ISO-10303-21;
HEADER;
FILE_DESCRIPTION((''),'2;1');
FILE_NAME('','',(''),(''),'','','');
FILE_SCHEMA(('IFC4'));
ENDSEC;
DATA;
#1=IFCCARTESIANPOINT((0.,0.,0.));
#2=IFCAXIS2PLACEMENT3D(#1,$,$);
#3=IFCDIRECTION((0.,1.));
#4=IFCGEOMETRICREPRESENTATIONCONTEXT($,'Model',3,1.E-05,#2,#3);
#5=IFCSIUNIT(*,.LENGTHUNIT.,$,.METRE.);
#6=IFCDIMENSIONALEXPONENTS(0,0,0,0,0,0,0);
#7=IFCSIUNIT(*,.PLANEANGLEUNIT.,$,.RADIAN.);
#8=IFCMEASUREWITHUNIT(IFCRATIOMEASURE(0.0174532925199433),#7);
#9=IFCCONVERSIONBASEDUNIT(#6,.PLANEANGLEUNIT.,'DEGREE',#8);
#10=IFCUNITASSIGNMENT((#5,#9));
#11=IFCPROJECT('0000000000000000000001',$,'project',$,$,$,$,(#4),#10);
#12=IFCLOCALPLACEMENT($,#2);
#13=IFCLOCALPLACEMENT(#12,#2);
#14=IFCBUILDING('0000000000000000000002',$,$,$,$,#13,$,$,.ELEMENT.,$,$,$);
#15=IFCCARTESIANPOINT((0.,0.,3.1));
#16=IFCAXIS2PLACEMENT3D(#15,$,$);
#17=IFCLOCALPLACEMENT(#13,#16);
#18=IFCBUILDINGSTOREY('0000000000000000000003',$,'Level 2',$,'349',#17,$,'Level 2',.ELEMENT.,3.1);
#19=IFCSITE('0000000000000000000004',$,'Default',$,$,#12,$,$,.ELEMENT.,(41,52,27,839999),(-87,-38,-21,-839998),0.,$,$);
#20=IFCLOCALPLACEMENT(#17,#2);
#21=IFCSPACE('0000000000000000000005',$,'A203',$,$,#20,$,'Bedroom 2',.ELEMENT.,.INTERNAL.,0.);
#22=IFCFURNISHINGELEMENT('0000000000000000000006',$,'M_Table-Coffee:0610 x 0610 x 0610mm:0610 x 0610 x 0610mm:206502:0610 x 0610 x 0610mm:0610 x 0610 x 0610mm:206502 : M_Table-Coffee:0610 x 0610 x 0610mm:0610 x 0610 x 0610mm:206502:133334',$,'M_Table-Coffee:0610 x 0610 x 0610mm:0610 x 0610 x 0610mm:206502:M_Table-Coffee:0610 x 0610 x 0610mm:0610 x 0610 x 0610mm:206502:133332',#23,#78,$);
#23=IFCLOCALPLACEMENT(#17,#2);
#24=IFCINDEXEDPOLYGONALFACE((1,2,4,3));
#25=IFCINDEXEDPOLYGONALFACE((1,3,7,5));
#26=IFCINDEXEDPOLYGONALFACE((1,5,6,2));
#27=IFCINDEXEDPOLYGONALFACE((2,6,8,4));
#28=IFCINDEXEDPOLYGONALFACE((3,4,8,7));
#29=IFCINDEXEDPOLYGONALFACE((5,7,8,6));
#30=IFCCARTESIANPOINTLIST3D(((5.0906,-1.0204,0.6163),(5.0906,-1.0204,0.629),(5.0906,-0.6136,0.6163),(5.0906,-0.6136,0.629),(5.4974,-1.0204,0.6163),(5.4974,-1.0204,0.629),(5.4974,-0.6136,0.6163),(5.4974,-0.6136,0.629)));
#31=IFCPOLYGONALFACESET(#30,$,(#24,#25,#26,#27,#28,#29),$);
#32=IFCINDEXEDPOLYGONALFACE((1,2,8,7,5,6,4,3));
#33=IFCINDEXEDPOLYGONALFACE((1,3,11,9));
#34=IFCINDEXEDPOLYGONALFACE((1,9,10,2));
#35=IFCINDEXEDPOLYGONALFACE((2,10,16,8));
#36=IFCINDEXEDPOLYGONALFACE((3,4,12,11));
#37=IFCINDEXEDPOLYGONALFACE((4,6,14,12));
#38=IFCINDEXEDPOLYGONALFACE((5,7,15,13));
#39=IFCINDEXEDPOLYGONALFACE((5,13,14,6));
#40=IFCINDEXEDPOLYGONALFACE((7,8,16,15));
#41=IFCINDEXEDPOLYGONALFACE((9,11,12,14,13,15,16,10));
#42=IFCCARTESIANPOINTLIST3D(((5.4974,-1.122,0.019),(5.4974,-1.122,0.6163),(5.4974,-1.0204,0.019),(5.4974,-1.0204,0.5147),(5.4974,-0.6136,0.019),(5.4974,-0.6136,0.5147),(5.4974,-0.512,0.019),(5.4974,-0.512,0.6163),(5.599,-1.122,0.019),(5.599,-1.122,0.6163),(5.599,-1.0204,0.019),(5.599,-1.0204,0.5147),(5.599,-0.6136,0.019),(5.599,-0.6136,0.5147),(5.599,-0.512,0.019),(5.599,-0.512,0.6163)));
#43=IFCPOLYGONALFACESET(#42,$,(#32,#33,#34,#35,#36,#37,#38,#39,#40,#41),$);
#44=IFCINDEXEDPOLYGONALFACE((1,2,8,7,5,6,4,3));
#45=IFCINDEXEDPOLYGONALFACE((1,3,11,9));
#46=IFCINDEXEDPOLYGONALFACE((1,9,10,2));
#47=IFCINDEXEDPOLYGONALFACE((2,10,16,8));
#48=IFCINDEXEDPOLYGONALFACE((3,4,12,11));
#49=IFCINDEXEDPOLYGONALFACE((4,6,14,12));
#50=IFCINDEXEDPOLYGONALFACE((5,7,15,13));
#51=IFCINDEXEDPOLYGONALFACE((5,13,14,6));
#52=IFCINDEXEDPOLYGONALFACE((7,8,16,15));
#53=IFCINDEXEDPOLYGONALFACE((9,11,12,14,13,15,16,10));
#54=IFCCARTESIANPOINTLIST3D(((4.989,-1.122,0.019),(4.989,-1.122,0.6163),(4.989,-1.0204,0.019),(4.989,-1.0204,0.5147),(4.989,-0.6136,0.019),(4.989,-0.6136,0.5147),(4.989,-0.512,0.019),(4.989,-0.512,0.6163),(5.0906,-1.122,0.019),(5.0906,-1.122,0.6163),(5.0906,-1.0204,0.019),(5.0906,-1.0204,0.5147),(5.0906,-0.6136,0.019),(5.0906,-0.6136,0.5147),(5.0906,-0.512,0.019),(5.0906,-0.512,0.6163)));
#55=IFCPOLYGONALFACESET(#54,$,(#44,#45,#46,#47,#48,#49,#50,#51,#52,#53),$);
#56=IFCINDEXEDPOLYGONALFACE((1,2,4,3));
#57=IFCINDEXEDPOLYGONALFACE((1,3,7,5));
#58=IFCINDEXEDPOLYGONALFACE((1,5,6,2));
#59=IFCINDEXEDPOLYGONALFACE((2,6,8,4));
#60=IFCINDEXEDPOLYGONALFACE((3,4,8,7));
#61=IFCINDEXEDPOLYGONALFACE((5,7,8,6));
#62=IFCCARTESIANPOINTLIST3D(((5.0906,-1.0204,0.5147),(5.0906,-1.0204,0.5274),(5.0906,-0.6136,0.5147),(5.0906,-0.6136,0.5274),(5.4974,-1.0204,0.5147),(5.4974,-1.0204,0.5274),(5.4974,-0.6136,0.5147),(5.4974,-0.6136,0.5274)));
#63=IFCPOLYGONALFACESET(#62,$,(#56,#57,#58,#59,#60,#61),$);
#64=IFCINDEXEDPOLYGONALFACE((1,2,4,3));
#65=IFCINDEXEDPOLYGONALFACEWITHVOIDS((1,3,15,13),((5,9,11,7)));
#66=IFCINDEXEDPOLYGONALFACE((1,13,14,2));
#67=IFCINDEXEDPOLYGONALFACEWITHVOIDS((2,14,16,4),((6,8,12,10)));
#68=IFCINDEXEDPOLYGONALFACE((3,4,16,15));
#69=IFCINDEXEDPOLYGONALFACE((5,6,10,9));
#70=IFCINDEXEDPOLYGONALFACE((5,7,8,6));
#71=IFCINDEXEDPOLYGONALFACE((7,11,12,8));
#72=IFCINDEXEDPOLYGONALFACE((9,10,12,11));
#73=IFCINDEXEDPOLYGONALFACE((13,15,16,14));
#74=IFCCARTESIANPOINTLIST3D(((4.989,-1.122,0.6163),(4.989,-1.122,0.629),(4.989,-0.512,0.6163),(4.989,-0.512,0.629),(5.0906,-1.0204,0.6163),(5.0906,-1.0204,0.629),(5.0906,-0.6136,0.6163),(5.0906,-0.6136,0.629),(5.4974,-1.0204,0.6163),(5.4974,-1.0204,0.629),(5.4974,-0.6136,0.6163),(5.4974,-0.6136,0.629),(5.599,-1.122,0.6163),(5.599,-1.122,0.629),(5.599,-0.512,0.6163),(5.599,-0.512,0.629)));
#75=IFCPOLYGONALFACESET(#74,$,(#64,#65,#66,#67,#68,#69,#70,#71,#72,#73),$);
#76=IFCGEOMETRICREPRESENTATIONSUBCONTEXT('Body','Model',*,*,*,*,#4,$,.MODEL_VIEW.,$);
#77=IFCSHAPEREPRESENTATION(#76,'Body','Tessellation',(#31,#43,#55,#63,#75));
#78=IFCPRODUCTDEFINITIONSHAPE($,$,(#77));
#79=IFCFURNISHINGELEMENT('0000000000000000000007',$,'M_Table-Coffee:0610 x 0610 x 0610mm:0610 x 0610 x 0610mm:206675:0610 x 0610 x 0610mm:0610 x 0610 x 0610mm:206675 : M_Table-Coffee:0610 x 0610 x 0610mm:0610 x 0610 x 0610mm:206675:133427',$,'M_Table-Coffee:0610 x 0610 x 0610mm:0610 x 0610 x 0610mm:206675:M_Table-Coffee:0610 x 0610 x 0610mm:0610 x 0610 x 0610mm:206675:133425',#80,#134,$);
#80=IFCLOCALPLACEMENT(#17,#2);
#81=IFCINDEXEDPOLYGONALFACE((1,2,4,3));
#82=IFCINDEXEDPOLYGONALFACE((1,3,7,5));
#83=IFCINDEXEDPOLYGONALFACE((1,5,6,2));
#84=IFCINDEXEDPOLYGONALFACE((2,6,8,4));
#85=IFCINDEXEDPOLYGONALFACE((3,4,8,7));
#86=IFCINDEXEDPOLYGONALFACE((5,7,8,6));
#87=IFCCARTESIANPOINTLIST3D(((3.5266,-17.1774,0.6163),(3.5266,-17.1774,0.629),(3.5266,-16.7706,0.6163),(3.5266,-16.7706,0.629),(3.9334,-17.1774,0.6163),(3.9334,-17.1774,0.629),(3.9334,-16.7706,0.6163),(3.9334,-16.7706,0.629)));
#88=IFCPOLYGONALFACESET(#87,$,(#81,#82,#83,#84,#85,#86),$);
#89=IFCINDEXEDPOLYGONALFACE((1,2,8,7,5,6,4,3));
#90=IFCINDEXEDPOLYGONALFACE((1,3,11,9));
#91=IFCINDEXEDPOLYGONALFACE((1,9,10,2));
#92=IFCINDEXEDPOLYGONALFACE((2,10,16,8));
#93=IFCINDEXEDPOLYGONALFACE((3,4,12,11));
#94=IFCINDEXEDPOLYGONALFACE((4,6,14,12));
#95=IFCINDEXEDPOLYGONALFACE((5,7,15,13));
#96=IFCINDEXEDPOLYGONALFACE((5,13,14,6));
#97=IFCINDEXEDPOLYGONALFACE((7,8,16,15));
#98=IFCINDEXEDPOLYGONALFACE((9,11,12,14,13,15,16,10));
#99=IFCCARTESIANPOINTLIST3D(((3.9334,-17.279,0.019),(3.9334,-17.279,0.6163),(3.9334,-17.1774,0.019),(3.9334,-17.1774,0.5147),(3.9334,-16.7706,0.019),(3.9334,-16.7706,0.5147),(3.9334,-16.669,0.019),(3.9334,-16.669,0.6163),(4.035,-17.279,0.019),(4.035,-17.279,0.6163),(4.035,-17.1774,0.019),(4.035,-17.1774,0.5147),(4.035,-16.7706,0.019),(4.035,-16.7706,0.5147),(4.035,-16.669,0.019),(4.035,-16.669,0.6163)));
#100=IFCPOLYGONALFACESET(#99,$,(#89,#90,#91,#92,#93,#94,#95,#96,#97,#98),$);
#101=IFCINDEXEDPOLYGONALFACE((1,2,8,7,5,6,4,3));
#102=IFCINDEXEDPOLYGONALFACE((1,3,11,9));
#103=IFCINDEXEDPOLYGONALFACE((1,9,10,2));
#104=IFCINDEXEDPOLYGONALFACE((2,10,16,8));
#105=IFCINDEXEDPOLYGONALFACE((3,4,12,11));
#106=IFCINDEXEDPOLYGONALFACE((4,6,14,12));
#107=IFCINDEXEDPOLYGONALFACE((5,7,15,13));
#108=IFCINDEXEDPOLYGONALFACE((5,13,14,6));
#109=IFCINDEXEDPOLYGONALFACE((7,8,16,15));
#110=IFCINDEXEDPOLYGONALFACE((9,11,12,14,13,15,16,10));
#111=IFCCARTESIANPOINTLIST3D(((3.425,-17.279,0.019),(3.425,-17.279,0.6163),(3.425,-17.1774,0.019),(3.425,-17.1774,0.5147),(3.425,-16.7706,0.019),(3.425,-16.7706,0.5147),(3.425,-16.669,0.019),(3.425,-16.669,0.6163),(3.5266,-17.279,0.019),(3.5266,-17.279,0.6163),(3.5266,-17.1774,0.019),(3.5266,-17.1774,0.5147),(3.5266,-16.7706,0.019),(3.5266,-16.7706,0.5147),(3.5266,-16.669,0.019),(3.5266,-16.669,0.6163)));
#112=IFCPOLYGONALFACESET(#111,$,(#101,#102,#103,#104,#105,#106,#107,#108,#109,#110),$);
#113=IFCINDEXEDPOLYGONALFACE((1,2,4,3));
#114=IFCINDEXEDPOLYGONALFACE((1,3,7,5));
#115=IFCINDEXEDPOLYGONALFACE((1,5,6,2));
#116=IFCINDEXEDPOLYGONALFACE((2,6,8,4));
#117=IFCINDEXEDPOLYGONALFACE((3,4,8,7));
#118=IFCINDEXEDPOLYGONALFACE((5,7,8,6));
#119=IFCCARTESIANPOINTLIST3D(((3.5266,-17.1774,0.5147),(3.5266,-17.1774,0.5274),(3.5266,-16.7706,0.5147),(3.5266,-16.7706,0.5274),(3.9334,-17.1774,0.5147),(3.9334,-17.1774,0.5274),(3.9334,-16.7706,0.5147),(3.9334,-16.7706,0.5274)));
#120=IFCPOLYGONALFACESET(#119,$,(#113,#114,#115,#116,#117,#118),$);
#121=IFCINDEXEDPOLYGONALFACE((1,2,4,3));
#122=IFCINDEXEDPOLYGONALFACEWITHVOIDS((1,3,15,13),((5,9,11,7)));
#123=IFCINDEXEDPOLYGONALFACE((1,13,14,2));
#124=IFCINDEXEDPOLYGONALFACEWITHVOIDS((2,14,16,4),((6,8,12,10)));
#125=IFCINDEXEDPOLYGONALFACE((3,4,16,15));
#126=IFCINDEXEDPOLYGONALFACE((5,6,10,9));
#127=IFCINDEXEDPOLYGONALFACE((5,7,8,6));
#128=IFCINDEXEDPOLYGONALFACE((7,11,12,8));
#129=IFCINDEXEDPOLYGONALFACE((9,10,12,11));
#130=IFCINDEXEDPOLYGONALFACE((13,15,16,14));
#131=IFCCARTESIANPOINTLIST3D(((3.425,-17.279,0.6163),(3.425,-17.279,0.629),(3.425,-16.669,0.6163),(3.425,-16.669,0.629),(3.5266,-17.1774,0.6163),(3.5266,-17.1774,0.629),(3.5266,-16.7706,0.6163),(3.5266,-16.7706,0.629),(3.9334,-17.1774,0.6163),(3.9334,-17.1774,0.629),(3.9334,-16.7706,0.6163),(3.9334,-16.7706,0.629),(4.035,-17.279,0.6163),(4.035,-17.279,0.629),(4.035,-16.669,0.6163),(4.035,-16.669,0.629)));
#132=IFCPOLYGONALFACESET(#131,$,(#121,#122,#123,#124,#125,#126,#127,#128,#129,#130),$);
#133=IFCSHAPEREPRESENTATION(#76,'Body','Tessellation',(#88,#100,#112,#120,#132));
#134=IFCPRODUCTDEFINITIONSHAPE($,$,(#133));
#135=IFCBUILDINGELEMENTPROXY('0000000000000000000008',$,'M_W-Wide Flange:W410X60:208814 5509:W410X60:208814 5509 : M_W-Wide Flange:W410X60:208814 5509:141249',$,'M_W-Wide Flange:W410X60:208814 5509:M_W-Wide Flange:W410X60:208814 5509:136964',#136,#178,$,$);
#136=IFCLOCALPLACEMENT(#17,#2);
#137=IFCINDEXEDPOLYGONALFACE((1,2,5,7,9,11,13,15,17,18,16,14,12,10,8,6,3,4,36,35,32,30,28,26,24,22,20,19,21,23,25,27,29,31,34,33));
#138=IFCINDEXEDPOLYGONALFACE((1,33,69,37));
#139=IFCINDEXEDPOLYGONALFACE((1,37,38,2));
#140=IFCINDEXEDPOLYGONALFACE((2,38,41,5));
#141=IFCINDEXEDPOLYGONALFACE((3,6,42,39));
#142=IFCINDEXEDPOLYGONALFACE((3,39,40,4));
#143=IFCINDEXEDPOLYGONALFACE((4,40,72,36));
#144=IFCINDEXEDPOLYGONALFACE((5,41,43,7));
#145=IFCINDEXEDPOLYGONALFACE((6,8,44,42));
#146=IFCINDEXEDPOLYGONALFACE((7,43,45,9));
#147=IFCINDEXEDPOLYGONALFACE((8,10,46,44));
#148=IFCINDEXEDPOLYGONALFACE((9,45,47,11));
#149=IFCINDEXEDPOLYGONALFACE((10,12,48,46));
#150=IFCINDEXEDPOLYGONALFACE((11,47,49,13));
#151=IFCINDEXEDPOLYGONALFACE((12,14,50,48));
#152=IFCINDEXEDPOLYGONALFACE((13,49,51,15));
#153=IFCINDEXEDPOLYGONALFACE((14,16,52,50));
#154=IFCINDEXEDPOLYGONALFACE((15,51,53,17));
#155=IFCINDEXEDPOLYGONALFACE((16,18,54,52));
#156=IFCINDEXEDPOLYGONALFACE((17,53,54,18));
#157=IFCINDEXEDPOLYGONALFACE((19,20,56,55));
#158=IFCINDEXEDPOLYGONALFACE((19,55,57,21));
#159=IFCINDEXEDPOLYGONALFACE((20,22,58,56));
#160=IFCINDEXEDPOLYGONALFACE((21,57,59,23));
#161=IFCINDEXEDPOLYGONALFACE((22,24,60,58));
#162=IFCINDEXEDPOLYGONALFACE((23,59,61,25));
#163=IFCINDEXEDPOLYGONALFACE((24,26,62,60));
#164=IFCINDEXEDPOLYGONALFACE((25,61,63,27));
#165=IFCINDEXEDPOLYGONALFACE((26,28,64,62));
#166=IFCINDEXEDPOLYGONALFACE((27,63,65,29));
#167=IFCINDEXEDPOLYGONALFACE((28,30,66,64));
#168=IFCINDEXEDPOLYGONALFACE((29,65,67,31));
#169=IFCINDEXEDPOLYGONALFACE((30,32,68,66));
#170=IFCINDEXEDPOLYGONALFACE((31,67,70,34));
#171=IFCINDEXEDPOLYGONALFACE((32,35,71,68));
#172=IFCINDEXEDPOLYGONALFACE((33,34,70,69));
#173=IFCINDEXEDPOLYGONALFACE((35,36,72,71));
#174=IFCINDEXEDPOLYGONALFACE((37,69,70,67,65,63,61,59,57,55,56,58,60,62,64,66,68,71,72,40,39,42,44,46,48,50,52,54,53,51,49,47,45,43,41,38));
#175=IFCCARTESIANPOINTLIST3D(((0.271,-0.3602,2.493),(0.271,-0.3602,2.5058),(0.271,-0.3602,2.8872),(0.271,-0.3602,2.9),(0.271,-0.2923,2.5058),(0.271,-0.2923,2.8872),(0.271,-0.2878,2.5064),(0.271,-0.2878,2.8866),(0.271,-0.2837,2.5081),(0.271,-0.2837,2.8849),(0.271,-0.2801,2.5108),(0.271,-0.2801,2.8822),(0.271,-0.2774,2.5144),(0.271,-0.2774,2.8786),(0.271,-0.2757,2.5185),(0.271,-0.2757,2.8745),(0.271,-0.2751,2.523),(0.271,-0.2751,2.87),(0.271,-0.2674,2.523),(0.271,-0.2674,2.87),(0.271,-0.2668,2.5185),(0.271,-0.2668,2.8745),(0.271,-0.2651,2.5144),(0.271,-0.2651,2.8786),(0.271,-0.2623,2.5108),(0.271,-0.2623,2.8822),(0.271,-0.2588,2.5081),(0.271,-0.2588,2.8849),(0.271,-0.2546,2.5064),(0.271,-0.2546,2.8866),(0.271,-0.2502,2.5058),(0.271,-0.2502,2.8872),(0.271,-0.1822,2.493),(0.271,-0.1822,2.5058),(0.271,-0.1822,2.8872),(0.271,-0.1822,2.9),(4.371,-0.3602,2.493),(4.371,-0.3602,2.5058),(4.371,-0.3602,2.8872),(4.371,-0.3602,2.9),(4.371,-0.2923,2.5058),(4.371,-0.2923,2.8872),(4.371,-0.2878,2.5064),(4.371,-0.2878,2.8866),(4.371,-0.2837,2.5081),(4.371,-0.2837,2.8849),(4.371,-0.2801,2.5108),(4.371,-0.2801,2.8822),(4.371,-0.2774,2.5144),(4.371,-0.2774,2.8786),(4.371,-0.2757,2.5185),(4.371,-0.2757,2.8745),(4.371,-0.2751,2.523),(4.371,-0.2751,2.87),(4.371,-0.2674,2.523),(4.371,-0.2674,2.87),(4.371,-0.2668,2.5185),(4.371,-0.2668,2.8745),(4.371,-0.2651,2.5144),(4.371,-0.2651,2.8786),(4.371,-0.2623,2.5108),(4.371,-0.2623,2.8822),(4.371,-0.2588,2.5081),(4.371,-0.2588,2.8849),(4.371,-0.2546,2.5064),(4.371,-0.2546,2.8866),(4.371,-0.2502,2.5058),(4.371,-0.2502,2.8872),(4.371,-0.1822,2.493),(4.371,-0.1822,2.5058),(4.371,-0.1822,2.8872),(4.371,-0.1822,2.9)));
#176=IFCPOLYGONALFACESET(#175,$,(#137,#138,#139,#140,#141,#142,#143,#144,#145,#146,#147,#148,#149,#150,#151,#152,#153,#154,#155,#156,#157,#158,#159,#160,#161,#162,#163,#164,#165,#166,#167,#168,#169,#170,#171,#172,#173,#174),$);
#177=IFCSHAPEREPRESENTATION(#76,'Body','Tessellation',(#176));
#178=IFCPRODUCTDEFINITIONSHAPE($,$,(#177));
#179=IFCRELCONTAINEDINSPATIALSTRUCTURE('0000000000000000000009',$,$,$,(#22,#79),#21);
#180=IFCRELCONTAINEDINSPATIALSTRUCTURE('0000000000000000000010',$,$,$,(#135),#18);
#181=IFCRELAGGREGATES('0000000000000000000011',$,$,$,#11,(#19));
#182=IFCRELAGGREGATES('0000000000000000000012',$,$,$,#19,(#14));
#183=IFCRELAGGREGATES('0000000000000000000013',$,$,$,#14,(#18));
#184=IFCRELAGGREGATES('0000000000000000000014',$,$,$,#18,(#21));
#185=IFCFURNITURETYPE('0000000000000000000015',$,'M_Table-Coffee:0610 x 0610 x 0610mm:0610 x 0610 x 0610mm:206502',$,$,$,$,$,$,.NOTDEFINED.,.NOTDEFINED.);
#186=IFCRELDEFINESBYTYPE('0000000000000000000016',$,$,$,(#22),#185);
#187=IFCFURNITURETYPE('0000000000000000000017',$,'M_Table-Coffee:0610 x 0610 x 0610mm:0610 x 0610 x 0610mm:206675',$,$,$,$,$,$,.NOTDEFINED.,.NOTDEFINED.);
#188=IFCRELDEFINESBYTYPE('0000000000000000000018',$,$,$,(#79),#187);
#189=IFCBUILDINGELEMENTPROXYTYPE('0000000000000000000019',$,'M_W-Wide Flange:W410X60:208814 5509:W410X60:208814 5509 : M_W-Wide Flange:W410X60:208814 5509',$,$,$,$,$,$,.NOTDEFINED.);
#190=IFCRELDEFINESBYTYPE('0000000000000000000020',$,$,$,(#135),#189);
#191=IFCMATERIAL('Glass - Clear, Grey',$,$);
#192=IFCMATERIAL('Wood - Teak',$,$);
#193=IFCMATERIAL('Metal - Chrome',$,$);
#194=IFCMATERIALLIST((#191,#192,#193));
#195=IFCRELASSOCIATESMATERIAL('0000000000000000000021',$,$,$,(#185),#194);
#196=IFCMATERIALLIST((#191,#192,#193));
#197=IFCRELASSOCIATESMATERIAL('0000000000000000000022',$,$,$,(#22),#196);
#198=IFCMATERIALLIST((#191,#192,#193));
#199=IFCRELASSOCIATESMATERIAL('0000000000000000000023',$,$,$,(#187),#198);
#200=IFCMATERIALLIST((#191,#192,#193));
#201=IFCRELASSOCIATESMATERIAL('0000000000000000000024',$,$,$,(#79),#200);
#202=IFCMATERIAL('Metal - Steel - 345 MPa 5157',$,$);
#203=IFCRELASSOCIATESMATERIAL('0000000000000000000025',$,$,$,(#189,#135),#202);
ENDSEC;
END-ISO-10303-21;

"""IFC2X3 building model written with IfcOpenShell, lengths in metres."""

from ifc_helpers import new_model, entity, si_unit, converted_unit, direction, frame, frame_2d, origin, origin_2d_with_axis, place, context, subcontext, project, spatial, polyline, rectangle, i_section, outline, extrude, source, transform, mapped, material, material_list, type_object, type_shapes, element, save


model = new_model("IFC2X3")

# Units and contexts
model_context = context("Model", 3, precision=1e-05, world=origin(), true_north=direction((0.0, 1.0)))
body_context = subcontext(model_context, "Body", "Model", "MODEL_VIEW")
ifc_project = project(units=[si_unit("LENGTHUNIT", "METRE"), converted_unit("PLANEANGLEUNIT", "DEGREE", entity("IfcRatioMeasure", 0.0174532925199433), si_unit("PLANEANGLEUNIT", "RADIAN"), dimensions=[0, 0, 0, 0, 0, 0, 0])], contexts=[model_context])

# Site, building, storey
site_placement = place(None, origin())
site = spatial("IfcSite", under=ifc_project, at=site_placement, Name="Default", CompositionType="ELEMENT", RefLatitude=(41, 52, 27, 839999), RefLongitude=(-87, -38, -21, -839998), RefElevation=0.0)
building_placement = place(site_placement, origin())
building = spatial("IfcBuilding", under=site, at=building_placement, CompositionType="ELEMENT")
storey_placement = place(building_placement, frame((0.0, 0.0, 3.1)))
storey = spatial("IfcBuildingStorey", under=building, at=storey_placement, Name="Level 2", ObjectType="349", LongName="Level 2", CompositionType="ELEMENT", Elevation=3.1)

# Shared definitions
space_placement = place(storey_placement, origin())
space = spatial("IfcSpace", under=storey, at=space_placement, Name="A203", LongName="Bedroom 2", CompositionType="ELEMENT", InteriorOrExteriorSpace="INTERNAL", ElevationWithFlooring=0.0)

# Furnishing elements
ifc_material_1 = material(Name="Glass - Clear, Grey")
ifc_material_2 = material(Name="Wood - Teak")
ifc_material_3 = material(Name="Metal - Chrome")
ifc_material_list_1 = material_list([ifc_material_1, ifc_material_2, ifc_material_3])
ifc_material_list_2 = material_list([ifc_material_1, ifc_material_2, ifc_material_3])
furniture_type_1 = type_object("IfcFurnitureType", Name="M_Table-Coffee:0610 x 0610 x 0610mm:0610 x 0610 x 0610mm:206502", material=ifc_material_list_2)
shared_shape_1 = source(origin(), body_context, "Body", "SweptSolid", [
    extrude(rectangle(XDim=0.4068, YDim=0.4068, at=frame_2d((0.0, 0.0), x_axis=(1.0, 0.0))), frame((5.294, -0.817, 3.7163), z_axis=(0.0, 0.0, 1.0), x_axis=(0.0, -1.0, 0.0)), (0.0, 0.0, 1.0), 0.0127),
    extrude(outline(polyline([(-0.305, -0.324), (0.305, -0.324), (0.305, 0.2732), (0.2034, 0.2732), (0.2034, -0.2225), (-0.2034, -0.2225), (-0.2034, 0.2732), (-0.305, 0.2732), (-0.305, -0.324)])), frame((5.4974, -0.817, 3.3923), z_axis=(1.0, 0.0, 0.0), x_axis=(0.0, -1.0, 0.0)), (0.0, 0.0, 1.0), 0.1016),
    extrude(outline(polyline([(-0.3241, -0.305), (0.2733, -0.305), (0.2733, -0.2034), (-0.2224, -0.2034), (-0.2224, 0.2034), (0.2733, 0.2034), (0.2733, 0.305), (-0.3241, 0.305), (-0.3241, -0.305)])), frame((4.989, -0.817, 3.3923), z_axis=(1.0, 0.0, 0.0), x_axis=(0.0, 0.0, -1.0)), (0.0, 0.0, 1.0), 0.1016),
    extrude(rectangle(XDim=0.4068, YDim=0.4068, at=origin_2d_with_axis()), frame((5.294, -0.817, 3.6147), z_axis=(0.0, 0.0, 1.0), x_axis=(0.0, -1.0, 0.0)), (0.0, 0.0, 1.0), 0.0127),
    extrude(outline(polyline([(-0.305, -0.305), (0.305, -0.305), (0.305, 0.305), (-0.305, 0.305), (-0.305, -0.305)]), holes=[polyline([(0.2034, 0.2034), (0.2034, -0.2034), (-0.2034, -0.2034), (-0.2034, 0.2034), (0.2034, 0.2034)])]), frame((5.294, -0.817, 3.7163), z_axis=(0.0, 0.0, 1.0), x_axis=(0.0, -1.0, 0.0)), (0.0, 0.0, 1.0), 0.0127),
])
type_shapes(furniture_type_1, [shared_shape_1])
furnishing_1_placement = place(space_placement, frame((0.0, 0.0, -3.1)))
element("IfcFurnishingElement", 1, at=furnishing_1_placement, inside=space, type_object=furniture_type_1, material=ifc_material_list_1, Name="M_Table-Coffee:0610 x 0610 x 0610mm:0610 x 0610 x 0610mm:206502:0610 x 0610 x 0610mm:0610 x 0610 x 0610mm:206502 : M_Table-Coffee:0610 x 0610 x 0610mm:0610 x 0610 x 0610mm:206502:133334", ObjectType="M_Table-Coffee:0610 x 0610 x 0610mm:0610 x 0610 x 0610mm:206502:M_Table-Coffee:0610 x 0610 x 0610mm:0610 x 0610 x 0610mm:206502:133332", context=body_context, shape_type="MappedRepresentation", body=[
    mapped(shared_shape_1, transform((0.0, 0.0, 0.0), scale=1.0)),
])
ifc_material_list_3 = material_list([ifc_material_1, ifc_material_2, ifc_material_3])
ifc_material_list_4 = material_list([ifc_material_1, ifc_material_2, ifc_material_3])
furniture_type_2 = type_object("IfcFurnitureType", Name="M_Table-Coffee:0610 x 0610 x 0610mm:0610 x 0610 x 0610mm:206675", material=ifc_material_list_4)
shared_shape_2 = source(origin(), body_context, "Body", "SweptSolid", [
    extrude(rectangle(XDim=0.4068, YDim=0.4068, at=frame_2d((0.0, 0.0), x_axis=(1.0, 0.0))), frame((3.73, -16.974, 3.7163), z_axis=(0.0, 0.0, 1.0), x_axis=(0.0, -1.0, 0.0)), (0.0, 0.0, 1.0), 0.0127),
    extrude(outline(polyline([(-0.305, -0.324), (0.305, -0.324), (0.305, 0.2732), (0.2034, 0.2732), (0.2034, -0.2225), (-0.2034, -0.2225), (-0.2034, 0.2732), (-0.305, 0.2732), (-0.305, -0.324)])), frame((3.9334, -16.974, 3.3923), z_axis=(1.0, 0.0, 0.0), x_axis=(0.0, -1.0, 0.0)), (0.0, 0.0, 1.0), 0.1016),
    extrude(outline(polyline([(-0.3241, -0.305), (0.2733, -0.305), (0.2733, -0.2034), (-0.2224, -0.2034), (-0.2224, 0.2034), (0.2733, 0.2034), (0.2733, 0.305), (-0.3241, 0.305), (-0.3241, -0.305)])), frame((3.425, -16.974, 3.3923), z_axis=(1.0, 0.0, 0.0), x_axis=(0.0, 0.0, -1.0)), (0.0, 0.0, 1.0), 0.1016),
    extrude(rectangle(XDim=0.4068, YDim=0.4068, at=frame_2d((0.0, 0.0), x_axis=(1.0, 0.0))), frame((3.73, -16.974, 3.6147), z_axis=(0.0, 0.0, 1.0), x_axis=(0.0, -1.0, 0.0)), (0.0, 0.0, 1.0), 0.0127),
    extrude(outline(polyline([(-0.305, -0.305), (0.305, -0.305), (0.305, 0.305), (-0.305, 0.305), (-0.305, -0.305)]), holes=[polyline([(0.2034, 0.2034), (0.2034, -0.2034), (-0.2034, -0.2034), (-0.2034, 0.2034), (0.2034, 0.2034)])]), frame((3.73, -16.974, 3.7163), z_axis=(0.0, 0.0, 1.0), x_axis=(0.0, -1.0, 0.0)), (0.0, 0.0, 1.0), 0.0127),
])
type_shapes(furniture_type_2, [shared_shape_2])
furnishing_2_placement = place(space_placement, frame((0.0, 0.0, -3.1)))
element("IfcFurnishingElement", 2, at=furnishing_2_placement, inside=space, type_object=furniture_type_2, material=ifc_material_list_3, Name="M_Table-Coffee:0610 x 0610 x 0610mm:0610 x 0610 x 0610mm:206675:0610 x 0610 x 0610mm:0610 x 0610 x 0610mm:206675 : M_Table-Coffee:0610 x 0610 x 0610mm:0610 x 0610 x 0610mm:206675:133427", ObjectType="M_Table-Coffee:0610 x 0610 x 0610mm:0610 x 0610 x 0610mm:206675:M_Table-Coffee:0610 x 0610 x 0610mm:0610 x 0610 x 0610mm:206675:133425", context=body_context, shape_type="MappedRepresentation", body=[
    mapped(shared_shape_2, transform((0.0, 0.0, 0.0), scale=1.0)),
])

# Building element proxy
ifc_material_4 = material(Name="Metal - Steel - 345 MPa 5157")
building_element_proxy_type_1 = type_object("IfcBuildingElementProxyType", Name="M_W-Wide Flange:W410X60:208814 5509:W410X60:208814 5509 : M_W-Wide Flange:W410X60:208814 5509", PredefinedType="NOTDEFINED", material=ifc_material_4)
shared_shape_3 = source(origin(), body_context, "Body", "SweptSolid", [
    extrude(i_section(OverallWidth=0.178, OverallDepth=0.407, WebThickness=0.0077, FlangeThickness=0.0128, FilletRadius=0.0172, at=frame_2d((0.0, 0.0), x_axis=(0.0, 1.0))), frame((0.0, 0.0, -0.2035), z_axis=(0.0, 1.0, 0.0), x_axis=(0.0, 0.0, 1.0)), (0.0, 0.0, 1.0), 4.1),
])
type_shapes(building_element_proxy_type_1, [shared_shape_3])
proxy_1_placement = place(storey_placement, frame((4.371, -0.2712, 2.9), z_axis=(0.0, 0.0, 1.0), x_axis=(0.0, 1.0, 0.0)))
element("IfcBuildingElementProxy", 3, at=proxy_1_placement, inside=storey, type_object=building_element_proxy_type_1, material=ifc_material_4, Name="M_W-Wide Flange:W410X60:208814 5509:W410X60:208814 5509 : M_W-Wide Flange:W410X60:208814 5509:141249", ObjectType="M_W-Wide Flange:W410X60:208814 5509:M_W-Wide Flange:W410X60:208814 5509:136964", context=body_context, shape_type="MappedRepresentation", body=[
    mapped(shared_shape_3, transform((0.0, 0.0, 0.0), scale=1.0)),
])

save(model, "model.ifc")
